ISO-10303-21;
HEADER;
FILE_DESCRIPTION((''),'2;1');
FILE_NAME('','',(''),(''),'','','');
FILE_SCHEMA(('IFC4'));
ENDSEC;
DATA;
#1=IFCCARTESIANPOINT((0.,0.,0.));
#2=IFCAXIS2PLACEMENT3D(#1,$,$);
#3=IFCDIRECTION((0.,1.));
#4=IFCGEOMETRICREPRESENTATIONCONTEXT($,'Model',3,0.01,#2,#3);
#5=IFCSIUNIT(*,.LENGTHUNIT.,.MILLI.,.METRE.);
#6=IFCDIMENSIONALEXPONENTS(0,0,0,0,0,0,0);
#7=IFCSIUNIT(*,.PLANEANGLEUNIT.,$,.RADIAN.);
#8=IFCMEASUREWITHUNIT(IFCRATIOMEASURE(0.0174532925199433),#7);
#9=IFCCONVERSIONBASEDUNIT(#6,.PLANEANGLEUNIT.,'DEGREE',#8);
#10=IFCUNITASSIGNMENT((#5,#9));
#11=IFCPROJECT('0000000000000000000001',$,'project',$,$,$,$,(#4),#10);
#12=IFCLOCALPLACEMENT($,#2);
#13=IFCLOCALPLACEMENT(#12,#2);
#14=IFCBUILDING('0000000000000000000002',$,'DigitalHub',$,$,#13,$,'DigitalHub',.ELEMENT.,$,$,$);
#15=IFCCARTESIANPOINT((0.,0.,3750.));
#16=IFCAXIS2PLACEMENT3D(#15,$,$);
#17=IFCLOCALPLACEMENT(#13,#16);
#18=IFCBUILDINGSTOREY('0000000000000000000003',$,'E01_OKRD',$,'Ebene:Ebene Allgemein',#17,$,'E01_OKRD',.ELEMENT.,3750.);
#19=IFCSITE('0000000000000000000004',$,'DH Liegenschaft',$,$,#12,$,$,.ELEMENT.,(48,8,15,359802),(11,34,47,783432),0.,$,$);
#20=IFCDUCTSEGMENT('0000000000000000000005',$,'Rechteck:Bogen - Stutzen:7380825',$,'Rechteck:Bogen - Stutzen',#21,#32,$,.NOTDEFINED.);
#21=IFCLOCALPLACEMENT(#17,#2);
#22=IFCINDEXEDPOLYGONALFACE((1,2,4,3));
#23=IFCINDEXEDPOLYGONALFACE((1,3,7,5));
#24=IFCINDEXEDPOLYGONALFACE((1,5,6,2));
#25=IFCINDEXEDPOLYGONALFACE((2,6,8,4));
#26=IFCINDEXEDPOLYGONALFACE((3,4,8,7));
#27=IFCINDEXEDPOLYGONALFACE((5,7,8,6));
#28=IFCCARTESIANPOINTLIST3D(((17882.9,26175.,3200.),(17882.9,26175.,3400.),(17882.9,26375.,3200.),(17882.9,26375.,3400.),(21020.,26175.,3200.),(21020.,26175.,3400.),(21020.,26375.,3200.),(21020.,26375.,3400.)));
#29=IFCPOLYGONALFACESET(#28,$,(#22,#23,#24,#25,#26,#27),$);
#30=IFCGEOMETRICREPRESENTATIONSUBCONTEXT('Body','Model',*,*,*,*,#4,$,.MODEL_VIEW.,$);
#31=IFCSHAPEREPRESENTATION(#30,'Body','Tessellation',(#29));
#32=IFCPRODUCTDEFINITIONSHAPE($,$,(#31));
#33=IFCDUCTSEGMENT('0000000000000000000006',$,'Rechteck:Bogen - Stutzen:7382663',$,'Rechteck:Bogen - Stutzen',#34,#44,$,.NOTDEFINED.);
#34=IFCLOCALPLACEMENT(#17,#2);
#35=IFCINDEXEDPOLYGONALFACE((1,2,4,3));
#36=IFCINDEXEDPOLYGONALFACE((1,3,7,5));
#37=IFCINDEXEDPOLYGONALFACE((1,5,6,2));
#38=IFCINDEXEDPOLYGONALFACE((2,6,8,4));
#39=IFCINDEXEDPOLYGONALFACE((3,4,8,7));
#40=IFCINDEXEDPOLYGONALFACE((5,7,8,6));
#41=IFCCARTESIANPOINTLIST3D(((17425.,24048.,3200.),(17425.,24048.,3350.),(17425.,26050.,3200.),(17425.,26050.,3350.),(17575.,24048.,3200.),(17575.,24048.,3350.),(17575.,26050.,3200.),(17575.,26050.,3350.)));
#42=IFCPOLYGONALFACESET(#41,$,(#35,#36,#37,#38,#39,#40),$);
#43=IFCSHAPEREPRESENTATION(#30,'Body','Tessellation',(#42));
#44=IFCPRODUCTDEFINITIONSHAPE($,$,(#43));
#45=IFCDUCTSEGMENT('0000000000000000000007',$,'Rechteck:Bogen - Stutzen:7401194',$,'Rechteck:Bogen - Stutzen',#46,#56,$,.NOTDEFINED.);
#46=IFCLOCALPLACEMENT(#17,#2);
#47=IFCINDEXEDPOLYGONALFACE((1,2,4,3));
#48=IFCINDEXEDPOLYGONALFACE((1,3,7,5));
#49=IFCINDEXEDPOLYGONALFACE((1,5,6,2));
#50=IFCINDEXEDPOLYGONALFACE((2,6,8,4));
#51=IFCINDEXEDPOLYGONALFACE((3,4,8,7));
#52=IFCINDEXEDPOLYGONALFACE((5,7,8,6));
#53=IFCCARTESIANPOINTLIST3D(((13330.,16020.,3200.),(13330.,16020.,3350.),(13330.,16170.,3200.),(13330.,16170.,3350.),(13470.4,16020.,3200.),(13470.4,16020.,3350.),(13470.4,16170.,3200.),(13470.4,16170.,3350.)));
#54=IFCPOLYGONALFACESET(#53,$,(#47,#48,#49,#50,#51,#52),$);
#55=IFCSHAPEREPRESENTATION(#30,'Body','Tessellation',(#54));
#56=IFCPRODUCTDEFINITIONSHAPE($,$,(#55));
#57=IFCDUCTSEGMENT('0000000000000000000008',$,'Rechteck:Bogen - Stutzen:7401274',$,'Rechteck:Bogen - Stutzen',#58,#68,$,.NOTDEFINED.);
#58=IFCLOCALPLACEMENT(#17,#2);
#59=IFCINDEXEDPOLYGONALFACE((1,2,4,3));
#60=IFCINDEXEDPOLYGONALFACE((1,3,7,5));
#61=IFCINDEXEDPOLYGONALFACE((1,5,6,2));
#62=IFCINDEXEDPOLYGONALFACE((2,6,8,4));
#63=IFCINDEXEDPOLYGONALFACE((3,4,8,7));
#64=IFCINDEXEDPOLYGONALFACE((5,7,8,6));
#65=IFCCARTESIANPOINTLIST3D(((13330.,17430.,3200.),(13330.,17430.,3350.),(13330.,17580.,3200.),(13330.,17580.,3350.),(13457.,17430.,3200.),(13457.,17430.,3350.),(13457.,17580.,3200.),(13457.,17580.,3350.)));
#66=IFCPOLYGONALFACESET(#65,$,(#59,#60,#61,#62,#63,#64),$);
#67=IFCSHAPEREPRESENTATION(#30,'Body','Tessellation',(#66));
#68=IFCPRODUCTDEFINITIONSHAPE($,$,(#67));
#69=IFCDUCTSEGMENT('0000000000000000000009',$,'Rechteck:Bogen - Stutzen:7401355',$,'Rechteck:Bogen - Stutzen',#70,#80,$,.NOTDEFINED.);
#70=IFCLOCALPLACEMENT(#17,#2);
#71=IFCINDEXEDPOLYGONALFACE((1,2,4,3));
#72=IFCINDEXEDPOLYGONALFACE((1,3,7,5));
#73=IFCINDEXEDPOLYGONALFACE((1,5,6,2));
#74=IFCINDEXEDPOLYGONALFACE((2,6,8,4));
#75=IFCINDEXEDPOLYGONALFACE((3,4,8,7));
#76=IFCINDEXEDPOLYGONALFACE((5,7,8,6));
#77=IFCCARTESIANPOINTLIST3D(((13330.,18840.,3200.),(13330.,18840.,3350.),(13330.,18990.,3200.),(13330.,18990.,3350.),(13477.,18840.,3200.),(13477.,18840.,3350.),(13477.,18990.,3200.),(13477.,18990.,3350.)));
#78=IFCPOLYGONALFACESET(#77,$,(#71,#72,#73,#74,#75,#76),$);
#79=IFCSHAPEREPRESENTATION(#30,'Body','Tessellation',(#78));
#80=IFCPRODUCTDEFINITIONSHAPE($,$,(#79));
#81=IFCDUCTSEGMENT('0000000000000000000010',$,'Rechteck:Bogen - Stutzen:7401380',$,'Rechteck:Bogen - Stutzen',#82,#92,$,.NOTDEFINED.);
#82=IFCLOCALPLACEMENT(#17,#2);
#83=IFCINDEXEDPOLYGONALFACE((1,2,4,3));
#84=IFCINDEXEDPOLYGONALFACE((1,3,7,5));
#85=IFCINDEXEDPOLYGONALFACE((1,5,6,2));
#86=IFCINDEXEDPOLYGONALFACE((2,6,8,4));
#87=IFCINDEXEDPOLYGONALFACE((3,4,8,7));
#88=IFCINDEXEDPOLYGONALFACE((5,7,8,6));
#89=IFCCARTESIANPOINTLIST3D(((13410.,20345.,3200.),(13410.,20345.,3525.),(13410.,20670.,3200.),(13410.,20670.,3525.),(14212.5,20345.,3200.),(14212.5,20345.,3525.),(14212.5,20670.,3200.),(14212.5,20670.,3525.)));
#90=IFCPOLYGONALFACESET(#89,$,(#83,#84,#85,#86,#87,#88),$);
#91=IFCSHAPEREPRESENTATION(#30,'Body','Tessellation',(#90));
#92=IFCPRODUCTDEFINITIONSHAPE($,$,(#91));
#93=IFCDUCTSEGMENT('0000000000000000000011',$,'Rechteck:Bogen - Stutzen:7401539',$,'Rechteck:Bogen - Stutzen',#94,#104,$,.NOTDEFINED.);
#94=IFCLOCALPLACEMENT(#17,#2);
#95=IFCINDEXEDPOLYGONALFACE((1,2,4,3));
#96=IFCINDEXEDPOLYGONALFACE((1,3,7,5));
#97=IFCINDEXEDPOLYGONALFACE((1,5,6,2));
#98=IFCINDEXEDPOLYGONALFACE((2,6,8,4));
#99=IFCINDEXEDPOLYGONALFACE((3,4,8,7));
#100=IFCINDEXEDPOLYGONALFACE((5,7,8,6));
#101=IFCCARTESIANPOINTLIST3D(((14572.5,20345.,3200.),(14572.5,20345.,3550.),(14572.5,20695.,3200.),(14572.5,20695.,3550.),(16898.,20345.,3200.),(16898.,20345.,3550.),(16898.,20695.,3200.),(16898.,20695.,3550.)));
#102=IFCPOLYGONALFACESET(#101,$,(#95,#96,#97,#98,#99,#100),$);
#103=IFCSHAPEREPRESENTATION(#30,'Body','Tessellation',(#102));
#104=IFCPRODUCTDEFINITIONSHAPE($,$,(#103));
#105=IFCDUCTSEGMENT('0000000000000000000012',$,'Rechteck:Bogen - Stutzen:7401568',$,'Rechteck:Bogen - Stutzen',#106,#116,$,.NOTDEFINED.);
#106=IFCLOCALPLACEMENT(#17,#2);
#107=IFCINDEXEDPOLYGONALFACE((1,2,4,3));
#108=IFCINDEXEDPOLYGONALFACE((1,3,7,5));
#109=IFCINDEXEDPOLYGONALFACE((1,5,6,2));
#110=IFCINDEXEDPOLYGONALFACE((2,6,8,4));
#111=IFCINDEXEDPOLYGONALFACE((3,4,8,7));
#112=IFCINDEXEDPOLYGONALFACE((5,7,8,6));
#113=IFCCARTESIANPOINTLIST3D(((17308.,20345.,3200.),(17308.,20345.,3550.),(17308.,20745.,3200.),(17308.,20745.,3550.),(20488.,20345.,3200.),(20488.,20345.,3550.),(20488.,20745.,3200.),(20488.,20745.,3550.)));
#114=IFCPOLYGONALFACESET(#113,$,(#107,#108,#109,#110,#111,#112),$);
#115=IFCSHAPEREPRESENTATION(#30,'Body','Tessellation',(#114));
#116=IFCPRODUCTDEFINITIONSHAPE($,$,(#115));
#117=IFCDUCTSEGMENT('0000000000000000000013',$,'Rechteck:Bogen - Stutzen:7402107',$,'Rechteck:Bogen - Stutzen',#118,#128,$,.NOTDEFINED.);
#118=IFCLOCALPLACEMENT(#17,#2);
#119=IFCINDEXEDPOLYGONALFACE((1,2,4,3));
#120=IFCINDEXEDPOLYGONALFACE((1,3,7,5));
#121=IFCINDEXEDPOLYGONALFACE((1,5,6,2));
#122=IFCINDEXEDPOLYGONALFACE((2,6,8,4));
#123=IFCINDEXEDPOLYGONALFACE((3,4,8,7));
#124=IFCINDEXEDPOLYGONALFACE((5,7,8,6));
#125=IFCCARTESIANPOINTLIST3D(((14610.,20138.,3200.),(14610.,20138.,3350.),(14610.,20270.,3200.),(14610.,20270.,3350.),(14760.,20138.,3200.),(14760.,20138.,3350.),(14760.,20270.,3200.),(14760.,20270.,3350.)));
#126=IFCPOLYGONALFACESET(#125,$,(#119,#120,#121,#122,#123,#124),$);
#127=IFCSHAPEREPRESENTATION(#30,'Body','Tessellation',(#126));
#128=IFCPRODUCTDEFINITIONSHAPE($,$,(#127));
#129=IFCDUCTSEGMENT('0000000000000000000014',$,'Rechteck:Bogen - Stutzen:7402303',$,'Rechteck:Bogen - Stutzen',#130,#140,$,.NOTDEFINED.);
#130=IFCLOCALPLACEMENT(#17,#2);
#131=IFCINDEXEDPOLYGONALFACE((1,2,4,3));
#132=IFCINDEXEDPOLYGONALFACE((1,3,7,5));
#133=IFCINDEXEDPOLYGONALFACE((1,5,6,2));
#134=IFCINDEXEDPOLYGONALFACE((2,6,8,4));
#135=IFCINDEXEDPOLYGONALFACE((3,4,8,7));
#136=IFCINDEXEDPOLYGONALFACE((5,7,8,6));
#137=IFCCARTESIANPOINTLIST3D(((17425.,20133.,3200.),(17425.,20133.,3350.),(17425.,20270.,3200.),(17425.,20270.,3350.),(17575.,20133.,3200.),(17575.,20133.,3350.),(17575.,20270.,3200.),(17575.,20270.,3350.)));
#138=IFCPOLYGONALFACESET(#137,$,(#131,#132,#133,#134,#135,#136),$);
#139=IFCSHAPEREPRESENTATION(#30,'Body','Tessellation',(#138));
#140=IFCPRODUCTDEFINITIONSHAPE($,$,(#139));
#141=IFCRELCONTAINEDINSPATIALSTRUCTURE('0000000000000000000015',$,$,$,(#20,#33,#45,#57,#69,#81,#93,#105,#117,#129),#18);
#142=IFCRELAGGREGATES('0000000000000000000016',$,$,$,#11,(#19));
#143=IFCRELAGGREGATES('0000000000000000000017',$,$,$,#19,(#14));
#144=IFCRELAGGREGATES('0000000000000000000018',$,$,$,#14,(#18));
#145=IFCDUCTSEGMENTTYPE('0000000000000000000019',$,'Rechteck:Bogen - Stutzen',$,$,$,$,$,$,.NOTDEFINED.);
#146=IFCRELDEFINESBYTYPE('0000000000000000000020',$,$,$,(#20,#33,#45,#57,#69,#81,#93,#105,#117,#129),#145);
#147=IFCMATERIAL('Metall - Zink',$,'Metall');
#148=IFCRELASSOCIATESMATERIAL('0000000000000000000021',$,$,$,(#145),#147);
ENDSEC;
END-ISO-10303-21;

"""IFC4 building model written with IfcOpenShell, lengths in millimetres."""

from ifc_helpers import new_model, entity, si_unit, converted_unit, direction, frame, origin, place, context, subcontext, project, spatial, indexed_curve, outline, extrude, material, type_object, element, save


model = new_model("IFC4")

# Units and contexts
model_context = context("Model", 3, precision=0.01, world=origin(), true_north=direction((0.0, 1.0)))
body_context = subcontext(model_context, "Body", "Model", "MODEL_VIEW")
ifc_project = project(units=[si_unit("LENGTHUNIT", "METRE", prefix="MILLI"), converted_unit("PLANEANGLEUNIT", "DEGREE", entity("IfcRatioMeasure", 0.0174532925199433), si_unit("PLANEANGLEUNIT", "RADIAN"), dimensions=[0, 0, 0, 0, 0, 0, 0])], contexts=[model_context])

# Site, building, storey
site_placement = place(None, origin())
site = spatial("IfcSite", under=ifc_project, at=site_placement, Name="DH Liegenschaft", CompositionType="ELEMENT", RefLatitude=(48, 8, 15, 359802), RefLongitude=(11, 34, 47, 783432), RefElevation=0.0)
building_placement = place(site_placement, origin())
building = spatial("IfcBuilding", under=site, at=building_placement, Name="DigitalHub", LongName="DigitalHub", CompositionType="ELEMENT")
storey_placement = place(building_placement, frame((0.0, 0.0, 3750.0)))
storey = spatial("IfcBuildingStorey", under=building, at=storey_placement, Name="E01_OKRD", ObjectType="Ebene:Ebene Allgemein", LongName="E01_OKRD", CompositionType="ELEMENT", Elevation=3750.0)

# Duct segments
ifc_material_1 = material(Name="Metall - Zink", Category="Metall")
duct_segment_type_1 = type_object("IfcDuctSegmentType", Name="Rechteck:Bogen - Stutzen", PredefinedType="NOTDEFINED", material=ifc_material_1)
duct_segment_1_placement = place(storey_placement, frame((17882.9, 26175.0, 3200.0)))
element("IfcDuctSegment", 1, at=duct_segment_1_placement, inside=storey, type_object=duct_segment_type_1, Name="Rechteck:Bogen - Stutzen:7380825", ObjectType="Rechteck:Bogen - Stutzen", PredefinedType="NOTDEFINED", context=body_context, shape_type="SweptSolid", body=[
    extrude(outline(indexed_curve([(-1568.5, -100.0), (1568.5, -100.0), (1568.5, 100.0), (-1568.5, 100.0), (-1568.5, -100.0)], self_intersect=False)), frame((1568.5, 100.0, 0.0), z_axis=(0.0, 0.0, 1.0), x_axis=(-1.0, 0.0, 0.0)), (0.0, 0.0, 1.0), 200.0),
])
duct_segment_2_placement = place(storey_placement, frame((17425.0, 24048.0, 3200.0)))
element("IfcDuctSegment", 2, at=duct_segment_2_placement, inside=storey, type_object=duct_segment_type_1, Name="Rechteck:Bogen - Stutzen:7382663", ObjectType="Rechteck:Bogen - Stutzen", PredefinedType="NOTDEFINED", context=body_context, shape_type="SweptSolid", body=[
    extrude(outline(indexed_curve([(-1001.0, -75.0), (1001.0, -75.0), (1001.0, 75.0), (-1001.0, 75.0), (-1001.0, -75.0)], self_intersect=False)), frame((75.0, 1001.0, 0.0), z_axis=(0.0, 0.0, 1.0), x_axis=(0.0, 1.0, 0.0)), (0.0, 0.0, 1.0), 150.0),
])
duct_segment_3_placement = place(storey_placement, frame((13330.0, 16020.0, 3200.0)))
element("IfcDuctSegment", 3, at=duct_segment_3_placement, inside=storey, type_object=duct_segment_type_1, Name="Rechteck:Bogen - Stutzen:7401194", ObjectType="Rechteck:Bogen - Stutzen", PredefinedType="NOTDEFINED", context=body_context, shape_type="SweptSolid", body=[
    extrude(outline(indexed_curve([(-70.2, -75.0), (70.2, -75.0), (70.2, 75.0), (-70.2, 75.0), (-70.2, -75.0)], self_intersect=False)), frame((70.2, 75.0, 0.0), z_axis=(0.0, 0.0, 1.0), x_axis=(-1.0, 0.0, 0.0)), (0.0, 0.0, 1.0), 150.0),
])
duct_segment_4_placement = place(storey_placement, frame((13330.0, 17430.0, 3200.0)))
element("IfcDuctSegment", 4, at=duct_segment_4_placement, inside=storey, type_object=duct_segment_type_1, Name="Rechteck:Bogen - Stutzen:7401274", ObjectType="Rechteck:Bogen - Stutzen", PredefinedType="NOTDEFINED", context=body_context, shape_type="SweptSolid", body=[
    extrude(outline(indexed_curve([(-63.5, -75.0), (63.5, -75.0), (63.5, 75.0), (-63.5, 75.0), (-63.5, -75.0)], self_intersect=False)), frame((63.5, 75.0, 0.0), z_axis=(0.0, 0.0, 1.0), x_axis=(-1.0, 0.0, 0.0)), (0.0, 0.0, 1.0), 150.0),
])
duct_segment_5_placement = place(storey_placement, frame((13330.0, 18840.0, 3200.0)))
element("IfcDuctSegment", 5, at=duct_segment_5_placement, inside=storey, type_object=duct_segment_type_1, Name="Rechteck:Bogen - Stutzen:7401355", ObjectType="Rechteck:Bogen - Stutzen", PredefinedType="NOTDEFINED", context=body_context, shape_type="SweptSolid", body=[
    extrude(outline(indexed_curve([(-73.5, -75.0), (73.5, -75.0), (73.5, 75.0), (-73.5, 75.0), (-73.5, -75.0)], self_intersect=False)), frame((73.5, 75.0, 0.0), z_axis=(0.0, 0.0, 1.0), x_axis=(-1.0, 0.0, 0.0)), (0.0, 0.0, 1.0), 150.0),
])
duct_segment_6_placement = place(storey_placement, frame((13410.0, 20345.0, 3200.0)))
element("IfcDuctSegment", 6, at=duct_segment_6_placement, inside=storey, type_object=duct_segment_type_1, Name="Rechteck:Bogen - Stutzen:7401380", ObjectType="Rechteck:Bogen - Stutzen", PredefinedType="NOTDEFINED", context=body_context, shape_type="SweptSolid", body=[
    extrude(outline(indexed_curve([(-401.3, -162.5), (401.3, -162.5), (401.3, 162.5), (-401.3, 162.5), (-401.3, -162.5)], self_intersect=False)), frame((401.3, 162.5, 0.0)), (0.0, 0.0, 1.0), 325.0),
])
duct_segment_7_placement = place(storey_placement, frame((14572.5, 20345.0, 3200.0)))
element("IfcDuctSegment", 7, at=duct_segment_7_placement, inside=storey, type_object=duct_segment_type_1, Name="Rechteck:Bogen - Stutzen:7401539", ObjectType="Rechteck:Bogen - Stutzen", PredefinedType="NOTDEFINED", context=body_context, shape_type="SweptSolid", body=[
    extrude(outline(indexed_curve([(-1162.8, -175.0), (1162.8, -175.0), (1162.8, 175.0), (-1162.8, 175.0), (-1162.8, -175.0)], self_intersect=False)), frame((1162.8, 175.0, 0.0)), (0.0, 0.0, 1.0), 350.0),
])
duct_segment_8_placement = place(storey_placement, frame((17308.0, 20345.0, 3200.0)))
element("IfcDuctSegment", 8, at=duct_segment_8_placement, inside=storey, type_object=duct_segment_type_1, Name="Rechteck:Bogen - Stutzen:7401568", ObjectType="Rechteck:Bogen - Stutzen", PredefinedType="NOTDEFINED", context=body_context, shape_type="SweptSolid", body=[
    extrude(outline(indexed_curve([(-1590.0, -200.0), (1590.0, -200.0), (1590.0, 200.0), (-1590.0, 200.0), (-1590.0, -200.0)], self_intersect=False)), frame((1590.0, 200.0, 0.0)), (0.0, 0.0, 1.0), 350.0),
])
duct_segment_9_placement = place(storey_placement, frame((14610.0, 20138.0, 3200.0)))
element("IfcDuctSegment", 9, at=duct_segment_9_placement, inside=storey, type_object=duct_segment_type_1, Name="Rechteck:Bogen - Stutzen:7402107", ObjectType="Rechteck:Bogen - Stutzen", PredefinedType="NOTDEFINED", context=body_context, shape_type="SweptSolid", body=[
    extrude(outline(indexed_curve([(-66.0, -75.0), (66.0, -75.0), (66.0, 75.0), (-66.0, 75.0), (-66.0, -75.0)], self_intersect=False)), frame((75.0, 66.0, 0.0), z_axis=(0.0, 0.0, 1.0), x_axis=(0.0, 1.0, 0.0)), (0.0, 0.0, 1.0), 150.0),
])
duct_segment_10_placement = place(storey_placement, frame((17425.0, 20133.0, 3200.0)))
element("IfcDuctSegment", 10, at=duct_segment_10_placement, inside=storey, type_object=duct_segment_type_1, Name="Rechteck:Bogen - Stutzen:7402303", ObjectType="Rechteck:Bogen - Stutzen", PredefinedType="NOTDEFINED", context=body_context, shape_type="SweptSolid", body=[
    extrude(outline(indexed_curve([(-68.5, -75.0), (68.5, -75.0), (68.5, 75.0), (-68.5, 75.0), (-68.5, -75.0)], self_intersect=False)), frame((75.0, 68.5, 0.0), z_axis=(0.0, 0.0, 1.0), x_axis=(0.0, 1.0, 0.0)), (0.0, 0.0, 1.0), 150.0),
])

save(model, "model.ifc")
